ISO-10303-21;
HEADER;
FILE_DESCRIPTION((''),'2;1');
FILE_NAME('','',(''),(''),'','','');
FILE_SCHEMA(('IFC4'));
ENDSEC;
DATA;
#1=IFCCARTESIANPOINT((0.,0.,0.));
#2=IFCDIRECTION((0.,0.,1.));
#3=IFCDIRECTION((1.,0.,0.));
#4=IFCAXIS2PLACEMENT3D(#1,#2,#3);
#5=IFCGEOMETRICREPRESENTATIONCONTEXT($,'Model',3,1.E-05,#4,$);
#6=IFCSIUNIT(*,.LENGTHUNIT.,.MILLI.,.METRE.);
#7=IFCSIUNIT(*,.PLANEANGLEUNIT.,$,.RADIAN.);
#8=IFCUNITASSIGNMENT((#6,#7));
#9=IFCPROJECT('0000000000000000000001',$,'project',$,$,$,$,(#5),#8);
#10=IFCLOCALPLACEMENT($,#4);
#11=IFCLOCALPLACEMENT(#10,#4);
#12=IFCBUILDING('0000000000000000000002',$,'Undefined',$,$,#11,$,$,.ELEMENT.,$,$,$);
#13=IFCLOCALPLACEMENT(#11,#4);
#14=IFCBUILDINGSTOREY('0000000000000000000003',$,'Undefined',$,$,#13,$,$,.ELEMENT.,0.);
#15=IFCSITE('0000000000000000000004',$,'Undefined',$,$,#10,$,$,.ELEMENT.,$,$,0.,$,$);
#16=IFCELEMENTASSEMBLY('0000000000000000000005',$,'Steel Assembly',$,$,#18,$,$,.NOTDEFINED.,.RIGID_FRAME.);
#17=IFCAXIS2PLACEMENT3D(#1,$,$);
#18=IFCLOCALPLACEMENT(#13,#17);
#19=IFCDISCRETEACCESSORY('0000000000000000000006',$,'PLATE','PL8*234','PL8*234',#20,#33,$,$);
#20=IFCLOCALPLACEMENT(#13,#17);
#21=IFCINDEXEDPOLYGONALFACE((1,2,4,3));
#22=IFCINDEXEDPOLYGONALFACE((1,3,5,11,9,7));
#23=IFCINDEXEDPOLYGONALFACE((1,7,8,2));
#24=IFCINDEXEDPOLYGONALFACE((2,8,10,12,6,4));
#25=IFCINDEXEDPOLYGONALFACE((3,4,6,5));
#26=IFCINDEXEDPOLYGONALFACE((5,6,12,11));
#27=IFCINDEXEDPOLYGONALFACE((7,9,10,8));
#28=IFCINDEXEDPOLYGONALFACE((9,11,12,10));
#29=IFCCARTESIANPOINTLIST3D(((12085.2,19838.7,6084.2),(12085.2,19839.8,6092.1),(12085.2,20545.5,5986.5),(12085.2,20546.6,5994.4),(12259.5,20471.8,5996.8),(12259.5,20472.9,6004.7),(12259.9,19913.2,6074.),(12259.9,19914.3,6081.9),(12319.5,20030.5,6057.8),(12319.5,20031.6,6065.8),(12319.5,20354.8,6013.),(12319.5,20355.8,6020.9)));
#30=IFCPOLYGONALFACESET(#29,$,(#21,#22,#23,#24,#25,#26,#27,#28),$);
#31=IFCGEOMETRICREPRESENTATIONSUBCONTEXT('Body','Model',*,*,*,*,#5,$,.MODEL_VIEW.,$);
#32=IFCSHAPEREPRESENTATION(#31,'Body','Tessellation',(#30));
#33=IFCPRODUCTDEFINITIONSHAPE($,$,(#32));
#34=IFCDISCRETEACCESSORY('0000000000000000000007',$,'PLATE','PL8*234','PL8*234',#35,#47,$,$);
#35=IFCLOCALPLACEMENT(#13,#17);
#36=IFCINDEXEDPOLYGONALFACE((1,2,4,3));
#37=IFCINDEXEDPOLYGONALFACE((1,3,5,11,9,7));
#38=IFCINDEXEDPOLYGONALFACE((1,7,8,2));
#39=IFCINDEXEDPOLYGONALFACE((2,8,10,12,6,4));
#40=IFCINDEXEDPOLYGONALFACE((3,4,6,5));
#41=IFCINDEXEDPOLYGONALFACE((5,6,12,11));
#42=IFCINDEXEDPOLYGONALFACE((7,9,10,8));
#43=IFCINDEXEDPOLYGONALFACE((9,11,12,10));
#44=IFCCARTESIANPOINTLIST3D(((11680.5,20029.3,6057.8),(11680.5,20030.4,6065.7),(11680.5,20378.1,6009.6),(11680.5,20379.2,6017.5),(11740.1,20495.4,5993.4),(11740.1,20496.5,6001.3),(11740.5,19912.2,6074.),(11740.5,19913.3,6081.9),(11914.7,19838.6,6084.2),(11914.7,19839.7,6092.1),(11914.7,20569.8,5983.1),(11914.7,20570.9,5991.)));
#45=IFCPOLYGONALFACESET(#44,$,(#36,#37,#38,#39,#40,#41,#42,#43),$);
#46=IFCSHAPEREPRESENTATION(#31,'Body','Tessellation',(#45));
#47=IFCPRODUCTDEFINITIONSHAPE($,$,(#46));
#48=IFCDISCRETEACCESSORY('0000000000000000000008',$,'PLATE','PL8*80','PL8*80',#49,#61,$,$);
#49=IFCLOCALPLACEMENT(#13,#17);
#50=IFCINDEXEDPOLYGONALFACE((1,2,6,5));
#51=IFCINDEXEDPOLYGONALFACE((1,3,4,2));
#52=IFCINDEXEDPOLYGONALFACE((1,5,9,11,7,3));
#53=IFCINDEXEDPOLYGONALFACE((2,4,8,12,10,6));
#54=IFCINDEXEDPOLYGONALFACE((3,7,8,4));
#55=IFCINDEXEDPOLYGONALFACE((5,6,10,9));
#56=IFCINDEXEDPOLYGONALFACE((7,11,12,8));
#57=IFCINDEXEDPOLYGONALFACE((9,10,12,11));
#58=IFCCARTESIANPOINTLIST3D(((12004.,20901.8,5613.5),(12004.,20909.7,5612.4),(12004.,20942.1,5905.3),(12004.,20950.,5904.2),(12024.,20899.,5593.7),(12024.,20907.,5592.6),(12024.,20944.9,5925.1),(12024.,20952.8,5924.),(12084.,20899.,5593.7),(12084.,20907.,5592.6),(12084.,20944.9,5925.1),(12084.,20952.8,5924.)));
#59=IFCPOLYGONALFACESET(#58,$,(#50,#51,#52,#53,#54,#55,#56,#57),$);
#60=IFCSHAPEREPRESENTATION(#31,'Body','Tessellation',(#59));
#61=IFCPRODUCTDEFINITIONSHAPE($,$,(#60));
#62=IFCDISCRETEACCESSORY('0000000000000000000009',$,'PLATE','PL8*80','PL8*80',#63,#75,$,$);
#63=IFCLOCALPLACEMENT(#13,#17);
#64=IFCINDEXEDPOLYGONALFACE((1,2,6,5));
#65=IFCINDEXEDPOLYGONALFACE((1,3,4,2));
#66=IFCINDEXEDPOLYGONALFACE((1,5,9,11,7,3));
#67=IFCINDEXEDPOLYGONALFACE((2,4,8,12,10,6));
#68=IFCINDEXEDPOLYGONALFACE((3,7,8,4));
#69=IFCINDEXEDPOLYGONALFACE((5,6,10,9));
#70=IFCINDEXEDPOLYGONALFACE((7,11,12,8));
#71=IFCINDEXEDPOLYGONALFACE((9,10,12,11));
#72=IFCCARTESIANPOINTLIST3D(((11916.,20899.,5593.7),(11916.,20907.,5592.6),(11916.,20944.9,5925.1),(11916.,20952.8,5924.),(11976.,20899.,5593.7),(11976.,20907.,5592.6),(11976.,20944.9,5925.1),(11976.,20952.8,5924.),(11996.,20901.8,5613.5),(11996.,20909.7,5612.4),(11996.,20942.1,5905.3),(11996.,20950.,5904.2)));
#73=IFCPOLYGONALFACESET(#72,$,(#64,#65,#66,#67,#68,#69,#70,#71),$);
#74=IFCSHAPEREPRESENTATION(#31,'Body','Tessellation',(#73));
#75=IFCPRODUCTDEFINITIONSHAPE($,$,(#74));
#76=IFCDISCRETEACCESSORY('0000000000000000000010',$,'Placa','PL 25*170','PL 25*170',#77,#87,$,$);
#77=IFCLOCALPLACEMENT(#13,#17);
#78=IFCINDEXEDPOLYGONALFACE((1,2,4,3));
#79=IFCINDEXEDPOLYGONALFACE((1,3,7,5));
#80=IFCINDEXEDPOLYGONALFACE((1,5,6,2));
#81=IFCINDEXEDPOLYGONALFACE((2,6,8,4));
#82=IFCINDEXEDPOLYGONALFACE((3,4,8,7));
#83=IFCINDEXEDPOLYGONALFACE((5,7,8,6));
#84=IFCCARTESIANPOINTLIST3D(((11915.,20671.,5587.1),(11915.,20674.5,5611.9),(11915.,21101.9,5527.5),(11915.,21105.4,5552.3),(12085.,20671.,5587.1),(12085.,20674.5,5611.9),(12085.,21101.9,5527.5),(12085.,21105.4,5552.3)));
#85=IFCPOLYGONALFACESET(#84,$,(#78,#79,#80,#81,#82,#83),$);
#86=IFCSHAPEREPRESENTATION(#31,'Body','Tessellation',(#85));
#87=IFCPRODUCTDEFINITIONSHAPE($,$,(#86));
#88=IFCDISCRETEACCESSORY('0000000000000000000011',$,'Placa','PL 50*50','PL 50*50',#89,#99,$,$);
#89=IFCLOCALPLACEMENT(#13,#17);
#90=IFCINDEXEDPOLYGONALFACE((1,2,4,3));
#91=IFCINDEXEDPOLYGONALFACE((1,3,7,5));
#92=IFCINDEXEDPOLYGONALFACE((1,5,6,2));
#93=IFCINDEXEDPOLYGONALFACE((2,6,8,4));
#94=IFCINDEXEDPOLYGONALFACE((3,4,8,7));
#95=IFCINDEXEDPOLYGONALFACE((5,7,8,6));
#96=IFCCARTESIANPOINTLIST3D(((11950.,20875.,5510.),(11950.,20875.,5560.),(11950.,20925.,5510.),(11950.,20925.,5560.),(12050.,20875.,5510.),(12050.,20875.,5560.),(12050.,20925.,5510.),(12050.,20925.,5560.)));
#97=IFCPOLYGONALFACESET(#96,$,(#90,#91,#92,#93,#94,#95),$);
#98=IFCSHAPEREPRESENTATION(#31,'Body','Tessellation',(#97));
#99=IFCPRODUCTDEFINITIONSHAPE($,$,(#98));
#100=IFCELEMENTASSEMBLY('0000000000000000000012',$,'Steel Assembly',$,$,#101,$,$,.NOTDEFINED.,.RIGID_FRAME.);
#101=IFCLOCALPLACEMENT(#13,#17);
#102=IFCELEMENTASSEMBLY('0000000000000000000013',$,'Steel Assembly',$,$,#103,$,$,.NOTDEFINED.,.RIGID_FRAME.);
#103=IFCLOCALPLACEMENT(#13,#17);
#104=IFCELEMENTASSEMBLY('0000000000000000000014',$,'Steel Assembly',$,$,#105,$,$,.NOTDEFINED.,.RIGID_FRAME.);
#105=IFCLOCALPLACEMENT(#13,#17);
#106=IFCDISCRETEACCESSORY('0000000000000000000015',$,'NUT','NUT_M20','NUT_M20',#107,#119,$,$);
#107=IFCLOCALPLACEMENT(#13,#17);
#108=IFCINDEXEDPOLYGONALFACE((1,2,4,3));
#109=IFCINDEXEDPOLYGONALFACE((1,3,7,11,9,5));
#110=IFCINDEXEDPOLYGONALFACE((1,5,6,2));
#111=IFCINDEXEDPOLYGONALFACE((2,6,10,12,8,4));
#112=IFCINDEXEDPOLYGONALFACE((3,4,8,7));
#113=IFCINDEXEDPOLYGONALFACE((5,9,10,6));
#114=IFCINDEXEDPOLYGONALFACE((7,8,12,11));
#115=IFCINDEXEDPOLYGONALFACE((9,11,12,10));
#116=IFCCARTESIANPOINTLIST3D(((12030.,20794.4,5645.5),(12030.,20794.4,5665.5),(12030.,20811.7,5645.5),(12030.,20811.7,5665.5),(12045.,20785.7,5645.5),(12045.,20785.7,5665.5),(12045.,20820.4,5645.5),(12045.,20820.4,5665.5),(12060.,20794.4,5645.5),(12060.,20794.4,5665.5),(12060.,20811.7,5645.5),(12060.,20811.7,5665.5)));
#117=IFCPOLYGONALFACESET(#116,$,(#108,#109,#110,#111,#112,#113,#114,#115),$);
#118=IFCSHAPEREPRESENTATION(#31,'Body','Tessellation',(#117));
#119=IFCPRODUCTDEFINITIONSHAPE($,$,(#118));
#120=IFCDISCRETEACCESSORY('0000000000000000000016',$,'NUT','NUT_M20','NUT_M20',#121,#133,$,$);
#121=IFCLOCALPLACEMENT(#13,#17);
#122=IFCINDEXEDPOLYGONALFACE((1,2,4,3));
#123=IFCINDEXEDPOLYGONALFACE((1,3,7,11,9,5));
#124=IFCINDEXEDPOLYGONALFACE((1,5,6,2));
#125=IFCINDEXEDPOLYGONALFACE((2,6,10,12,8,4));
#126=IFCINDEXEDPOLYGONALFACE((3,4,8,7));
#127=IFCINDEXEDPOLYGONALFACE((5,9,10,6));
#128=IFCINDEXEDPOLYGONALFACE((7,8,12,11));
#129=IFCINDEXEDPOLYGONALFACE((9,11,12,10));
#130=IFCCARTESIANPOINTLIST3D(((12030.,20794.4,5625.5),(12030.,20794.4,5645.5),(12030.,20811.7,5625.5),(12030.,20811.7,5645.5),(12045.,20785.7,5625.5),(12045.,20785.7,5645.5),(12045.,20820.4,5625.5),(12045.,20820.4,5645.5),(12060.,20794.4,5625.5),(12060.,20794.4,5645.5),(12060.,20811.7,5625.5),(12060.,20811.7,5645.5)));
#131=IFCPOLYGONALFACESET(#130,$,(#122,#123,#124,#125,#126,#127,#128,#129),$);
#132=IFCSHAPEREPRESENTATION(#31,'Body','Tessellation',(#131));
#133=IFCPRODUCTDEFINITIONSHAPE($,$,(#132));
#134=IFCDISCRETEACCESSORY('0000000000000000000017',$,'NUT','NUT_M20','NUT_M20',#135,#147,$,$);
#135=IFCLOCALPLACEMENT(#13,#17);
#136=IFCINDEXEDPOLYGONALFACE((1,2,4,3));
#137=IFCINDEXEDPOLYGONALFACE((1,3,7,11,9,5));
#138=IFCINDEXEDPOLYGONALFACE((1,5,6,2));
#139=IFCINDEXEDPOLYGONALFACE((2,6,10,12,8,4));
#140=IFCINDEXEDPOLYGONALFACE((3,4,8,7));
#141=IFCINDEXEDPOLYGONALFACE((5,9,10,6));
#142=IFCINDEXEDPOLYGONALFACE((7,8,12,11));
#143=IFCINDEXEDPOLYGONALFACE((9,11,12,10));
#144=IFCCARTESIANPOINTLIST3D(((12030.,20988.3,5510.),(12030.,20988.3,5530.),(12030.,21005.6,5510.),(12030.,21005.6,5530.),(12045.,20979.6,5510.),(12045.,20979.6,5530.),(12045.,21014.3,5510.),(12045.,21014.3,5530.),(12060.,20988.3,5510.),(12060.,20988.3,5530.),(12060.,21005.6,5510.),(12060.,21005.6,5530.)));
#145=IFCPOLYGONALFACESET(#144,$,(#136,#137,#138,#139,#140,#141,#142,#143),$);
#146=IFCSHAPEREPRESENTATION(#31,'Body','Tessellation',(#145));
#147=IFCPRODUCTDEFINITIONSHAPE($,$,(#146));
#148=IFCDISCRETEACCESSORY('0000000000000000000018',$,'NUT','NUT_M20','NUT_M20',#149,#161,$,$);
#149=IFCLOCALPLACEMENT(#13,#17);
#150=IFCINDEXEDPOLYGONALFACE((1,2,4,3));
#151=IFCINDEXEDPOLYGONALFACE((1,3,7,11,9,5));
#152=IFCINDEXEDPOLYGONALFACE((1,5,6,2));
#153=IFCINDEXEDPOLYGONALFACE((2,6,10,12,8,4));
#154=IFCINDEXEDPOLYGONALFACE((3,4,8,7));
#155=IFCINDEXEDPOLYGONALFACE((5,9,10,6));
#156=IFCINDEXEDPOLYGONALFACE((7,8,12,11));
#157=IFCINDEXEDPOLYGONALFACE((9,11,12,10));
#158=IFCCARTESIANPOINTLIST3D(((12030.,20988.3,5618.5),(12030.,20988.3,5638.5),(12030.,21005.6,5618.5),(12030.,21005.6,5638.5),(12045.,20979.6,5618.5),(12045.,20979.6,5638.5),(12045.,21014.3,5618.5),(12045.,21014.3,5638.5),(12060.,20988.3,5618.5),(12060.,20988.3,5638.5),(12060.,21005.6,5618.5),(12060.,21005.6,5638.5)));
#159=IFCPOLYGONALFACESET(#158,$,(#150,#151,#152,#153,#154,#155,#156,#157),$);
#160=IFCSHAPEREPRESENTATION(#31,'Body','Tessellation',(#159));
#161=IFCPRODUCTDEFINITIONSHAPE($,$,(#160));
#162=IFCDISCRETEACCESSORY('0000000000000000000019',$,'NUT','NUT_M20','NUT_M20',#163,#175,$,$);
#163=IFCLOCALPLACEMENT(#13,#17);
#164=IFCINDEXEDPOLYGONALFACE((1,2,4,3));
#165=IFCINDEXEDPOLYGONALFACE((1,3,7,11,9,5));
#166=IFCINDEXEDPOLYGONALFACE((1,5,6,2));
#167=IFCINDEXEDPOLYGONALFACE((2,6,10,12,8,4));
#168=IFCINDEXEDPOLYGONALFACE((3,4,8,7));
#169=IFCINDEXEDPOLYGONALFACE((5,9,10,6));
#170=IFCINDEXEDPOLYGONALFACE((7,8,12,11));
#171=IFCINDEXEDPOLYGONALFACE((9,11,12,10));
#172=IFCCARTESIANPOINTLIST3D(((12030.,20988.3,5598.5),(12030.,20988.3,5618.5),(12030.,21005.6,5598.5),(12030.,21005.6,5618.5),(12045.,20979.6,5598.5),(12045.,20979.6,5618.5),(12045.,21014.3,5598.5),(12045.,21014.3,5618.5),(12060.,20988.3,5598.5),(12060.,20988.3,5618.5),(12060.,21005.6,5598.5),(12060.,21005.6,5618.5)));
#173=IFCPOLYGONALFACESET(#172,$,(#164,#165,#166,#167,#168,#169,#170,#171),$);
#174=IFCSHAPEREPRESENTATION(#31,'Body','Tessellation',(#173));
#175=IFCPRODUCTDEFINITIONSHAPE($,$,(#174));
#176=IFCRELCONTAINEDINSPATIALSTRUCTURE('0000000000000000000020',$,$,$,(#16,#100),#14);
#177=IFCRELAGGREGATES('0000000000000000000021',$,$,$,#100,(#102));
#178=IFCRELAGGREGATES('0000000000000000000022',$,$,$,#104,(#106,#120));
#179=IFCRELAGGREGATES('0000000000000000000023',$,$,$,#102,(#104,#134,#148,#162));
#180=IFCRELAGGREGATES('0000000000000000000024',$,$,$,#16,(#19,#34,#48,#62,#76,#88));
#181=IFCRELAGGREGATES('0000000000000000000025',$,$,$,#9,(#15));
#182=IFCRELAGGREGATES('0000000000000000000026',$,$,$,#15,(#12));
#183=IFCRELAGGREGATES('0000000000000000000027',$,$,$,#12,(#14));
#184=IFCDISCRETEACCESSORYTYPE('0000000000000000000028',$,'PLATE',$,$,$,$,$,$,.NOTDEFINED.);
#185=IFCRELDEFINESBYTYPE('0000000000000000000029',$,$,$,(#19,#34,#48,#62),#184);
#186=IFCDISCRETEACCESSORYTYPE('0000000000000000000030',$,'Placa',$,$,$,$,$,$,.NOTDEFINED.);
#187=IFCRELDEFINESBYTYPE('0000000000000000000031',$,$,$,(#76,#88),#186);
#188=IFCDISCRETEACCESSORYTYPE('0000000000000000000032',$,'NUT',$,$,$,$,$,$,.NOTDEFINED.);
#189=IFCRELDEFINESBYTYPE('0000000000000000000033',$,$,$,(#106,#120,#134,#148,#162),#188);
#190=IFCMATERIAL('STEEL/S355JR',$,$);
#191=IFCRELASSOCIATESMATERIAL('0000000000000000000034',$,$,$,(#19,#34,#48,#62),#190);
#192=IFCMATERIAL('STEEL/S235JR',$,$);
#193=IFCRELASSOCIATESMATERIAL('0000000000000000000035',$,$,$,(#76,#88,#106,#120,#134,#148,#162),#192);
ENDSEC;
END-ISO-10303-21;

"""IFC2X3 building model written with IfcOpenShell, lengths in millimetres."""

from ifc_helpers import new_model, si_unit, frame, origin_with_axes, place, context, subcontext, project, spatial, polyline, outline, extrude, material, type_object, element, aggregate, save


model = new_model("IFC2X3")

# Units and contexts
model_context = context("Model", 3, precision=1e-05, world=origin_with_axes())
body_context = subcontext(model_context, "Body", "Model", "MODEL_VIEW")
ifc_project = project(units=[si_unit("LENGTHUNIT", "METRE", prefix="MILLI"), si_unit("PLANEANGLEUNIT", "RADIAN")], contexts=[model_context])

# Site, building, storey
site_placement = place(None, origin_with_axes())
site = spatial("IfcSite", under=ifc_project, at=site_placement, Name="Undefined", CompositionType="ELEMENT", RefElevation=0.0)
building_placement = place(site_placement, origin_with_axes())
building = spatial("IfcBuilding", under=site, at=building_placement, Name="Undefined", CompositionType="ELEMENT")
storey_placement = place(building_placement, origin_with_axes())
storey = spatial("IfcBuildingStorey", under=building, at=storey_placement, Name="Undefined", CompositionType="ELEMENT", Elevation=0.0)

# Element assembly, discrete accessories
assembly_1_placement = place(storey_placement, origin_with_axes())
assembly_1 = element("IfcElementAssembly", 1, at=assembly_1_placement, inside=storey, Name="Steel Assembly", AssemblyPlace="NOTDEFINED", PredefinedType="RIGID_FRAME")
ifc_material_1 = material(Name="STEEL/S355JR")
discrete_accessory_type_1 = type_object("IfcDiscreteAccessoryType", Name="PLATE")
discrete_accessory_1_placement = place(assembly_1_placement, frame((12085.2, 20546.0, 5990.5), z_axis=(-0.000554, 0.13698, 0.990574), x_axis=(0.0, -0.990574, 0.13698)))
discrete_accessory_1 = element("IfcDiscreteAccessory", 2, at=discrete_accessory_1_placement, type_object=discrete_accessory_type_1, material=ifc_material_1, Name="PLATE", Description="PL8*234", ObjectType="PL8*234", context=body_context, shape_type="SweptSolid", body=[
    extrude(outline(polyline([(0.0, 0.0), (713.5, 0.0), (638.3, 174.6), (519.9, 234.3), (192.5, 234.3), (74.3, 174.2), (0.0, 0.0)])), frame((0.0, 0.0, -4.0), z_axis=(0.0, 0.0, 1.0), x_axis=(1.0, 0.0, 0.0)), (0.0, 0.0, 1.0), 8.0),
])
discrete_accessory_2_placement = place(assembly_1_placement, frame((11914.7, 20570.4, 5987.0), z_axis=(0.000018, -0.13698, -0.990574), x_axis=(0.0, -0.990574, 0.13698)))
discrete_accessory_2 = element("IfcDiscreteAccessory", 3, at=discrete_accessory_2_placement, type_object=discrete_accessory_type_1, material=ifc_material_1, Name="PLATE", Description="PL8*234", ObjectType="PL8*234", context=body_context, shape_type="SweptSolid", body=[
    extrude(outline(polyline([(0.0, 0.0), (738.2, 0.0), (663.9, 174.2), (545.6, 234.3), (193.6, 234.3), (75.2, 174.6), (0.0, 0.0)])), frame((0.0, 0.0, -4.0), z_axis=(0.0, 0.0, 1.0), x_axis=(1.0, 0.0, 0.0)), (0.0, 0.0, 1.0), 8.0),
])
discrete_accessory_3_placement = place(assembly_1_placement, frame((12084.0, 20903.0, 5593.1), z_axis=(0.0, 0.990574, -0.13698), x_axis=(-1.0, 0.0, 0.0)))
discrete_accessory_3 = element("IfcDiscreteAccessory", 4, at=discrete_accessory_3_placement, type_object=discrete_accessory_type_1, material=ifc_material_1, Name="PLATE", Description="PL8*80", ObjectType="PL8*80", context=body_context, shape_type="SweptSolid", body=[
    extrude(outline(polyline([(0.0, 0.0), (60.0, 0.0), (80.0, 20.0), (80.0, 314.6), (60.0, 334.6), (0.0, 334.6), (0.0, 0.0)])), frame((0.0, 0.0, -4.0), z_axis=(0.0, 0.0, 1.0), x_axis=(1.0, 0.0, 0.0)), (0.0, 0.0, 1.0), 8.0),
])
discrete_accessory_4_placement = place(assembly_1_placement, frame((11996.0, 20903.0, 5593.1), z_axis=(0.0, 0.990574, -0.13698), x_axis=(-1.0, 0.0, 0.0)))
discrete_accessory_4 = element("IfcDiscreteAccessory", 5, at=discrete_accessory_4_placement, type_object=discrete_accessory_type_1, material=ifc_material_1, Name="PLATE", Description="PL8*80", ObjectType="PL8*80", context=body_context, shape_type="SweptSolid", body=[
    extrude(outline(polyline([(0.0, 20.0), (20.0, 0.0), (80.0, 0.0), (80.0, 334.6), (20.0, 334.6), (0.0, 314.6), (0.0, 20.0)])), frame((0.0, 0.0, -4.0), z_axis=(0.0, 0.0, 1.0), x_axis=(1.0, 0.0, 0.0)), (0.0, 0.0, 1.0), 8.0),
])
ifc_material_2 = material(Name="STEEL/S235JR")
discrete_accessory_type_2 = type_object("IfcDiscreteAccessoryType", Name="Placa")
discrete_accessory_5_placement = place(assembly_1_placement, frame((12085.0, 21103.7, 5539.9), z_axis=(0.0, -0.13698, -0.990574), x_axis=(0.0, -0.990574, 0.13698)))
discrete_accessory_5 = element("IfcDiscreteAccessory", 6, at=discrete_accessory_5_placement, type_object=discrete_accessory_type_2, material=ifc_material_2, Name="Placa", Description="PL 25*170", ObjectType="PL 25*170", context=body_context, shape_type="SweptSolid", body=[
    extrude(outline(polyline([(0.0, 0.0), (435.0, 0.0), (435.0, 170.0), (0.0, 170.0), (0.0, 0.0)])), frame((0.0, 0.0, -12.5), z_axis=(0.0, 0.0, 1.0), x_axis=(1.0, 0.0, 0.0)), (0.0, 0.0, 1.0), 25.0),
])
discrete_accessory_6_placement = place(assembly_1_placement, frame((11950.0, 20925.0, 5535.0), z_axis=(0.0, 0.0, -1.0), x_axis=(1.0, 0.0, 0.0)))
discrete_accessory_6 = element("IfcDiscreteAccessory", 7, at=discrete_accessory_6_placement, type_object=discrete_accessory_type_2, material=ifc_material_2, Name="Placa", Description="PL 50*50", ObjectType="PL 50*50", context=body_context, shape_type="SweptSolid", body=[
    extrude(outline(polyline([(0.0, 0.0), (100.0, 0.0), (100.0, 50.0), (0.0, 50.0), (0.0, 0.0)])), frame((0.0, 0.0, -25.0), z_axis=(0.0, 0.0, 1.0), x_axis=(1.0, 0.0, 0.0)), (0.0, 0.0, 1.0), 50.0),
])

# Element assemblies, discrete accessories
assembly_2_placement = place(storey_placement, origin_with_axes())
assembly_2 = element("IfcElementAssembly", 8, at=assembly_2_placement, inside=storey, Name="Steel Assembly", AssemblyPlace="NOTDEFINED", PredefinedType="RIGID_FRAME")
assembly_3_placement = place(assembly_2_placement, origin_with_axes())
assembly_3 = element("IfcElementAssembly", 9, at=assembly_3_placement, Name="Steel Assembly", AssemblyPlace="NOTDEFINED", PredefinedType="RIGID_FRAME")
aggregate(assembly_2, [assembly_3])
assembly_4_placement = place(assembly_3_placement, origin_with_axes())
assembly_4 = element("IfcElementAssembly", 10, at=assembly_4_placement, Name="Steel Assembly", AssemblyPlace="NOTDEFINED", PredefinedType="RIGID_FRAME")
discrete_accessory_type_3 = type_object("IfcDiscreteAccessoryType", Name="NUT")
discrete_accessory_7_placement = place(assembly_4_placement, frame((12045.0, 20803.0, 5665.5), z_axis=(-1.0, 0.0, 0.0), x_axis=(0.0, 0.0, -1.0)))
discrete_accessory_7 = element("IfcDiscreteAccessory", 11, at=discrete_accessory_7_placement, type_object=discrete_accessory_type_3, material=ifc_material_2, Name="NUT", Description="NUT_M20", ObjectType="NUT_M20", context=body_context, shape_type="SweptSolid", body=[
    extrude(outline(polyline([(8.7, 15.0), (17.3, 0.0), (8.7, -15.0), (-8.7, -15.0), (-17.3, 0.0), (-8.7, 15.0), (8.7, 15.0)])), frame((20.0, 0.0, 0.0), z_axis=(-1.0, 0.0, 0.0), x_axis=(0.0, -1.0, 0.0)), (0.0, 0.0, 1.0), 20.0),
])
discrete_accessory_8_placement = place(assembly_4_placement, frame((12045.0, 20803.0, 5645.5), z_axis=(-1.0, 0.0, 0.0), x_axis=(0.0, 0.0, -1.0)))
discrete_accessory_8 = element("IfcDiscreteAccessory", 12, at=discrete_accessory_8_placement, type_object=discrete_accessory_type_3, material=ifc_material_2, Name="NUT", Description="NUT_M20", ObjectType="NUT_M20", context=body_context, shape_type="SweptSolid", body=[
    extrude(outline(polyline([(8.7, 15.0), (17.3, 0.0), (8.7, -15.0), (-8.7, -15.0), (-17.3, 0.0), (-8.7, 15.0), (8.7, 15.0)])), frame((20.0, 0.0, 0.0), z_axis=(-1.0, 0.0, 0.0), x_axis=(0.0, -1.0, 0.0)), (0.0, 0.0, 1.0), 20.0),
])
discrete_accessory_9_placement = place(assembly_3_placement, frame((12045.0, 20997.0, 5530.0), z_axis=(-1.0, 0.0, 0.0), x_axis=(0.0, 0.0, -1.0)))
discrete_accessory_9 = element("IfcDiscreteAccessory", 13, at=discrete_accessory_9_placement, type_object=discrete_accessory_type_3, material=ifc_material_2, Name="NUT", Description="NUT_M20", ObjectType="NUT_M20", context=body_context, shape_type="SweptSolid", body=[
    extrude(outline(polyline([(8.7, 15.0), (17.3, 0.0), (8.7, -15.0), (-8.7, -15.0), (-17.3, 0.0), (-8.7, 15.0), (8.7, 15.0)])), frame((20.0, 0.0, 0.0), z_axis=(-1.0, 0.0, 0.0), x_axis=(0.0, -1.0, 0.0)), (0.0, 0.0, 1.0), 20.0),
])
discrete_accessory_10_placement = place(assembly_3_placement, frame((12045.0, 20997.0, 5638.5), z_axis=(-1.0, 0.0, 0.0), x_axis=(0.0, 0.0, -1.0)))
discrete_accessory_10 = element("IfcDiscreteAccessory", 14, at=discrete_accessory_10_placement, type_object=discrete_accessory_type_3, material=ifc_material_2, Name="NUT", Description="NUT_M20", ObjectType="NUT_M20", context=body_context, shape_type="SweptSolid", body=[
    extrude(outline(polyline([(8.7, 15.0), (17.3, 0.0), (8.7, -15.0), (-8.7, -15.0), (-17.3, 0.0), (-8.7, 15.0), (8.7, 15.0)])), frame((20.0, 0.0, 0.0), z_axis=(-1.0, 0.0, 0.0), x_axis=(0.0, -1.0, 0.0)), (0.0, 0.0, 1.0), 20.0),
])
discrete_accessory_11_placement = place(assembly_3_placement, frame((12045.0, 20997.0, 5618.5), z_axis=(-1.0, 0.0, 0.0), x_axis=(0.0, 0.0, -1.0)))
discrete_accessory_11 = element("IfcDiscreteAccessory", 15, at=discrete_accessory_11_placement, type_object=discrete_accessory_type_3, material=ifc_material_2, Name="NUT", Description="NUT_M20", ObjectType="NUT_M20", context=body_context, shape_type="SweptSolid", body=[
    extrude(outline(polyline([(8.7, 15.0), (17.3, 0.0), (8.7, -15.0), (-8.7, -15.0), (-17.3, 0.0), (-8.7, 15.0), (8.7, 15.0)])), frame((20.0, 0.0, 0.0), z_axis=(-1.0, 0.0, 0.0), x_axis=(0.0, -1.0, 0.0)), (0.0, 0.0, 1.0), 20.0),
])

aggregate(assembly_4, [discrete_accessory_7, discrete_accessory_8])
aggregate(assembly_3, [assembly_4, discrete_accessory_9, discrete_accessory_10, discrete_accessory_11])

aggregate(assembly_1, [discrete_accessory_1, discrete_accessory_2, discrete_accessory_3, discrete_accessory_4, discrete_accessory_5, discrete_accessory_6])

save(model, "model.ifc")
